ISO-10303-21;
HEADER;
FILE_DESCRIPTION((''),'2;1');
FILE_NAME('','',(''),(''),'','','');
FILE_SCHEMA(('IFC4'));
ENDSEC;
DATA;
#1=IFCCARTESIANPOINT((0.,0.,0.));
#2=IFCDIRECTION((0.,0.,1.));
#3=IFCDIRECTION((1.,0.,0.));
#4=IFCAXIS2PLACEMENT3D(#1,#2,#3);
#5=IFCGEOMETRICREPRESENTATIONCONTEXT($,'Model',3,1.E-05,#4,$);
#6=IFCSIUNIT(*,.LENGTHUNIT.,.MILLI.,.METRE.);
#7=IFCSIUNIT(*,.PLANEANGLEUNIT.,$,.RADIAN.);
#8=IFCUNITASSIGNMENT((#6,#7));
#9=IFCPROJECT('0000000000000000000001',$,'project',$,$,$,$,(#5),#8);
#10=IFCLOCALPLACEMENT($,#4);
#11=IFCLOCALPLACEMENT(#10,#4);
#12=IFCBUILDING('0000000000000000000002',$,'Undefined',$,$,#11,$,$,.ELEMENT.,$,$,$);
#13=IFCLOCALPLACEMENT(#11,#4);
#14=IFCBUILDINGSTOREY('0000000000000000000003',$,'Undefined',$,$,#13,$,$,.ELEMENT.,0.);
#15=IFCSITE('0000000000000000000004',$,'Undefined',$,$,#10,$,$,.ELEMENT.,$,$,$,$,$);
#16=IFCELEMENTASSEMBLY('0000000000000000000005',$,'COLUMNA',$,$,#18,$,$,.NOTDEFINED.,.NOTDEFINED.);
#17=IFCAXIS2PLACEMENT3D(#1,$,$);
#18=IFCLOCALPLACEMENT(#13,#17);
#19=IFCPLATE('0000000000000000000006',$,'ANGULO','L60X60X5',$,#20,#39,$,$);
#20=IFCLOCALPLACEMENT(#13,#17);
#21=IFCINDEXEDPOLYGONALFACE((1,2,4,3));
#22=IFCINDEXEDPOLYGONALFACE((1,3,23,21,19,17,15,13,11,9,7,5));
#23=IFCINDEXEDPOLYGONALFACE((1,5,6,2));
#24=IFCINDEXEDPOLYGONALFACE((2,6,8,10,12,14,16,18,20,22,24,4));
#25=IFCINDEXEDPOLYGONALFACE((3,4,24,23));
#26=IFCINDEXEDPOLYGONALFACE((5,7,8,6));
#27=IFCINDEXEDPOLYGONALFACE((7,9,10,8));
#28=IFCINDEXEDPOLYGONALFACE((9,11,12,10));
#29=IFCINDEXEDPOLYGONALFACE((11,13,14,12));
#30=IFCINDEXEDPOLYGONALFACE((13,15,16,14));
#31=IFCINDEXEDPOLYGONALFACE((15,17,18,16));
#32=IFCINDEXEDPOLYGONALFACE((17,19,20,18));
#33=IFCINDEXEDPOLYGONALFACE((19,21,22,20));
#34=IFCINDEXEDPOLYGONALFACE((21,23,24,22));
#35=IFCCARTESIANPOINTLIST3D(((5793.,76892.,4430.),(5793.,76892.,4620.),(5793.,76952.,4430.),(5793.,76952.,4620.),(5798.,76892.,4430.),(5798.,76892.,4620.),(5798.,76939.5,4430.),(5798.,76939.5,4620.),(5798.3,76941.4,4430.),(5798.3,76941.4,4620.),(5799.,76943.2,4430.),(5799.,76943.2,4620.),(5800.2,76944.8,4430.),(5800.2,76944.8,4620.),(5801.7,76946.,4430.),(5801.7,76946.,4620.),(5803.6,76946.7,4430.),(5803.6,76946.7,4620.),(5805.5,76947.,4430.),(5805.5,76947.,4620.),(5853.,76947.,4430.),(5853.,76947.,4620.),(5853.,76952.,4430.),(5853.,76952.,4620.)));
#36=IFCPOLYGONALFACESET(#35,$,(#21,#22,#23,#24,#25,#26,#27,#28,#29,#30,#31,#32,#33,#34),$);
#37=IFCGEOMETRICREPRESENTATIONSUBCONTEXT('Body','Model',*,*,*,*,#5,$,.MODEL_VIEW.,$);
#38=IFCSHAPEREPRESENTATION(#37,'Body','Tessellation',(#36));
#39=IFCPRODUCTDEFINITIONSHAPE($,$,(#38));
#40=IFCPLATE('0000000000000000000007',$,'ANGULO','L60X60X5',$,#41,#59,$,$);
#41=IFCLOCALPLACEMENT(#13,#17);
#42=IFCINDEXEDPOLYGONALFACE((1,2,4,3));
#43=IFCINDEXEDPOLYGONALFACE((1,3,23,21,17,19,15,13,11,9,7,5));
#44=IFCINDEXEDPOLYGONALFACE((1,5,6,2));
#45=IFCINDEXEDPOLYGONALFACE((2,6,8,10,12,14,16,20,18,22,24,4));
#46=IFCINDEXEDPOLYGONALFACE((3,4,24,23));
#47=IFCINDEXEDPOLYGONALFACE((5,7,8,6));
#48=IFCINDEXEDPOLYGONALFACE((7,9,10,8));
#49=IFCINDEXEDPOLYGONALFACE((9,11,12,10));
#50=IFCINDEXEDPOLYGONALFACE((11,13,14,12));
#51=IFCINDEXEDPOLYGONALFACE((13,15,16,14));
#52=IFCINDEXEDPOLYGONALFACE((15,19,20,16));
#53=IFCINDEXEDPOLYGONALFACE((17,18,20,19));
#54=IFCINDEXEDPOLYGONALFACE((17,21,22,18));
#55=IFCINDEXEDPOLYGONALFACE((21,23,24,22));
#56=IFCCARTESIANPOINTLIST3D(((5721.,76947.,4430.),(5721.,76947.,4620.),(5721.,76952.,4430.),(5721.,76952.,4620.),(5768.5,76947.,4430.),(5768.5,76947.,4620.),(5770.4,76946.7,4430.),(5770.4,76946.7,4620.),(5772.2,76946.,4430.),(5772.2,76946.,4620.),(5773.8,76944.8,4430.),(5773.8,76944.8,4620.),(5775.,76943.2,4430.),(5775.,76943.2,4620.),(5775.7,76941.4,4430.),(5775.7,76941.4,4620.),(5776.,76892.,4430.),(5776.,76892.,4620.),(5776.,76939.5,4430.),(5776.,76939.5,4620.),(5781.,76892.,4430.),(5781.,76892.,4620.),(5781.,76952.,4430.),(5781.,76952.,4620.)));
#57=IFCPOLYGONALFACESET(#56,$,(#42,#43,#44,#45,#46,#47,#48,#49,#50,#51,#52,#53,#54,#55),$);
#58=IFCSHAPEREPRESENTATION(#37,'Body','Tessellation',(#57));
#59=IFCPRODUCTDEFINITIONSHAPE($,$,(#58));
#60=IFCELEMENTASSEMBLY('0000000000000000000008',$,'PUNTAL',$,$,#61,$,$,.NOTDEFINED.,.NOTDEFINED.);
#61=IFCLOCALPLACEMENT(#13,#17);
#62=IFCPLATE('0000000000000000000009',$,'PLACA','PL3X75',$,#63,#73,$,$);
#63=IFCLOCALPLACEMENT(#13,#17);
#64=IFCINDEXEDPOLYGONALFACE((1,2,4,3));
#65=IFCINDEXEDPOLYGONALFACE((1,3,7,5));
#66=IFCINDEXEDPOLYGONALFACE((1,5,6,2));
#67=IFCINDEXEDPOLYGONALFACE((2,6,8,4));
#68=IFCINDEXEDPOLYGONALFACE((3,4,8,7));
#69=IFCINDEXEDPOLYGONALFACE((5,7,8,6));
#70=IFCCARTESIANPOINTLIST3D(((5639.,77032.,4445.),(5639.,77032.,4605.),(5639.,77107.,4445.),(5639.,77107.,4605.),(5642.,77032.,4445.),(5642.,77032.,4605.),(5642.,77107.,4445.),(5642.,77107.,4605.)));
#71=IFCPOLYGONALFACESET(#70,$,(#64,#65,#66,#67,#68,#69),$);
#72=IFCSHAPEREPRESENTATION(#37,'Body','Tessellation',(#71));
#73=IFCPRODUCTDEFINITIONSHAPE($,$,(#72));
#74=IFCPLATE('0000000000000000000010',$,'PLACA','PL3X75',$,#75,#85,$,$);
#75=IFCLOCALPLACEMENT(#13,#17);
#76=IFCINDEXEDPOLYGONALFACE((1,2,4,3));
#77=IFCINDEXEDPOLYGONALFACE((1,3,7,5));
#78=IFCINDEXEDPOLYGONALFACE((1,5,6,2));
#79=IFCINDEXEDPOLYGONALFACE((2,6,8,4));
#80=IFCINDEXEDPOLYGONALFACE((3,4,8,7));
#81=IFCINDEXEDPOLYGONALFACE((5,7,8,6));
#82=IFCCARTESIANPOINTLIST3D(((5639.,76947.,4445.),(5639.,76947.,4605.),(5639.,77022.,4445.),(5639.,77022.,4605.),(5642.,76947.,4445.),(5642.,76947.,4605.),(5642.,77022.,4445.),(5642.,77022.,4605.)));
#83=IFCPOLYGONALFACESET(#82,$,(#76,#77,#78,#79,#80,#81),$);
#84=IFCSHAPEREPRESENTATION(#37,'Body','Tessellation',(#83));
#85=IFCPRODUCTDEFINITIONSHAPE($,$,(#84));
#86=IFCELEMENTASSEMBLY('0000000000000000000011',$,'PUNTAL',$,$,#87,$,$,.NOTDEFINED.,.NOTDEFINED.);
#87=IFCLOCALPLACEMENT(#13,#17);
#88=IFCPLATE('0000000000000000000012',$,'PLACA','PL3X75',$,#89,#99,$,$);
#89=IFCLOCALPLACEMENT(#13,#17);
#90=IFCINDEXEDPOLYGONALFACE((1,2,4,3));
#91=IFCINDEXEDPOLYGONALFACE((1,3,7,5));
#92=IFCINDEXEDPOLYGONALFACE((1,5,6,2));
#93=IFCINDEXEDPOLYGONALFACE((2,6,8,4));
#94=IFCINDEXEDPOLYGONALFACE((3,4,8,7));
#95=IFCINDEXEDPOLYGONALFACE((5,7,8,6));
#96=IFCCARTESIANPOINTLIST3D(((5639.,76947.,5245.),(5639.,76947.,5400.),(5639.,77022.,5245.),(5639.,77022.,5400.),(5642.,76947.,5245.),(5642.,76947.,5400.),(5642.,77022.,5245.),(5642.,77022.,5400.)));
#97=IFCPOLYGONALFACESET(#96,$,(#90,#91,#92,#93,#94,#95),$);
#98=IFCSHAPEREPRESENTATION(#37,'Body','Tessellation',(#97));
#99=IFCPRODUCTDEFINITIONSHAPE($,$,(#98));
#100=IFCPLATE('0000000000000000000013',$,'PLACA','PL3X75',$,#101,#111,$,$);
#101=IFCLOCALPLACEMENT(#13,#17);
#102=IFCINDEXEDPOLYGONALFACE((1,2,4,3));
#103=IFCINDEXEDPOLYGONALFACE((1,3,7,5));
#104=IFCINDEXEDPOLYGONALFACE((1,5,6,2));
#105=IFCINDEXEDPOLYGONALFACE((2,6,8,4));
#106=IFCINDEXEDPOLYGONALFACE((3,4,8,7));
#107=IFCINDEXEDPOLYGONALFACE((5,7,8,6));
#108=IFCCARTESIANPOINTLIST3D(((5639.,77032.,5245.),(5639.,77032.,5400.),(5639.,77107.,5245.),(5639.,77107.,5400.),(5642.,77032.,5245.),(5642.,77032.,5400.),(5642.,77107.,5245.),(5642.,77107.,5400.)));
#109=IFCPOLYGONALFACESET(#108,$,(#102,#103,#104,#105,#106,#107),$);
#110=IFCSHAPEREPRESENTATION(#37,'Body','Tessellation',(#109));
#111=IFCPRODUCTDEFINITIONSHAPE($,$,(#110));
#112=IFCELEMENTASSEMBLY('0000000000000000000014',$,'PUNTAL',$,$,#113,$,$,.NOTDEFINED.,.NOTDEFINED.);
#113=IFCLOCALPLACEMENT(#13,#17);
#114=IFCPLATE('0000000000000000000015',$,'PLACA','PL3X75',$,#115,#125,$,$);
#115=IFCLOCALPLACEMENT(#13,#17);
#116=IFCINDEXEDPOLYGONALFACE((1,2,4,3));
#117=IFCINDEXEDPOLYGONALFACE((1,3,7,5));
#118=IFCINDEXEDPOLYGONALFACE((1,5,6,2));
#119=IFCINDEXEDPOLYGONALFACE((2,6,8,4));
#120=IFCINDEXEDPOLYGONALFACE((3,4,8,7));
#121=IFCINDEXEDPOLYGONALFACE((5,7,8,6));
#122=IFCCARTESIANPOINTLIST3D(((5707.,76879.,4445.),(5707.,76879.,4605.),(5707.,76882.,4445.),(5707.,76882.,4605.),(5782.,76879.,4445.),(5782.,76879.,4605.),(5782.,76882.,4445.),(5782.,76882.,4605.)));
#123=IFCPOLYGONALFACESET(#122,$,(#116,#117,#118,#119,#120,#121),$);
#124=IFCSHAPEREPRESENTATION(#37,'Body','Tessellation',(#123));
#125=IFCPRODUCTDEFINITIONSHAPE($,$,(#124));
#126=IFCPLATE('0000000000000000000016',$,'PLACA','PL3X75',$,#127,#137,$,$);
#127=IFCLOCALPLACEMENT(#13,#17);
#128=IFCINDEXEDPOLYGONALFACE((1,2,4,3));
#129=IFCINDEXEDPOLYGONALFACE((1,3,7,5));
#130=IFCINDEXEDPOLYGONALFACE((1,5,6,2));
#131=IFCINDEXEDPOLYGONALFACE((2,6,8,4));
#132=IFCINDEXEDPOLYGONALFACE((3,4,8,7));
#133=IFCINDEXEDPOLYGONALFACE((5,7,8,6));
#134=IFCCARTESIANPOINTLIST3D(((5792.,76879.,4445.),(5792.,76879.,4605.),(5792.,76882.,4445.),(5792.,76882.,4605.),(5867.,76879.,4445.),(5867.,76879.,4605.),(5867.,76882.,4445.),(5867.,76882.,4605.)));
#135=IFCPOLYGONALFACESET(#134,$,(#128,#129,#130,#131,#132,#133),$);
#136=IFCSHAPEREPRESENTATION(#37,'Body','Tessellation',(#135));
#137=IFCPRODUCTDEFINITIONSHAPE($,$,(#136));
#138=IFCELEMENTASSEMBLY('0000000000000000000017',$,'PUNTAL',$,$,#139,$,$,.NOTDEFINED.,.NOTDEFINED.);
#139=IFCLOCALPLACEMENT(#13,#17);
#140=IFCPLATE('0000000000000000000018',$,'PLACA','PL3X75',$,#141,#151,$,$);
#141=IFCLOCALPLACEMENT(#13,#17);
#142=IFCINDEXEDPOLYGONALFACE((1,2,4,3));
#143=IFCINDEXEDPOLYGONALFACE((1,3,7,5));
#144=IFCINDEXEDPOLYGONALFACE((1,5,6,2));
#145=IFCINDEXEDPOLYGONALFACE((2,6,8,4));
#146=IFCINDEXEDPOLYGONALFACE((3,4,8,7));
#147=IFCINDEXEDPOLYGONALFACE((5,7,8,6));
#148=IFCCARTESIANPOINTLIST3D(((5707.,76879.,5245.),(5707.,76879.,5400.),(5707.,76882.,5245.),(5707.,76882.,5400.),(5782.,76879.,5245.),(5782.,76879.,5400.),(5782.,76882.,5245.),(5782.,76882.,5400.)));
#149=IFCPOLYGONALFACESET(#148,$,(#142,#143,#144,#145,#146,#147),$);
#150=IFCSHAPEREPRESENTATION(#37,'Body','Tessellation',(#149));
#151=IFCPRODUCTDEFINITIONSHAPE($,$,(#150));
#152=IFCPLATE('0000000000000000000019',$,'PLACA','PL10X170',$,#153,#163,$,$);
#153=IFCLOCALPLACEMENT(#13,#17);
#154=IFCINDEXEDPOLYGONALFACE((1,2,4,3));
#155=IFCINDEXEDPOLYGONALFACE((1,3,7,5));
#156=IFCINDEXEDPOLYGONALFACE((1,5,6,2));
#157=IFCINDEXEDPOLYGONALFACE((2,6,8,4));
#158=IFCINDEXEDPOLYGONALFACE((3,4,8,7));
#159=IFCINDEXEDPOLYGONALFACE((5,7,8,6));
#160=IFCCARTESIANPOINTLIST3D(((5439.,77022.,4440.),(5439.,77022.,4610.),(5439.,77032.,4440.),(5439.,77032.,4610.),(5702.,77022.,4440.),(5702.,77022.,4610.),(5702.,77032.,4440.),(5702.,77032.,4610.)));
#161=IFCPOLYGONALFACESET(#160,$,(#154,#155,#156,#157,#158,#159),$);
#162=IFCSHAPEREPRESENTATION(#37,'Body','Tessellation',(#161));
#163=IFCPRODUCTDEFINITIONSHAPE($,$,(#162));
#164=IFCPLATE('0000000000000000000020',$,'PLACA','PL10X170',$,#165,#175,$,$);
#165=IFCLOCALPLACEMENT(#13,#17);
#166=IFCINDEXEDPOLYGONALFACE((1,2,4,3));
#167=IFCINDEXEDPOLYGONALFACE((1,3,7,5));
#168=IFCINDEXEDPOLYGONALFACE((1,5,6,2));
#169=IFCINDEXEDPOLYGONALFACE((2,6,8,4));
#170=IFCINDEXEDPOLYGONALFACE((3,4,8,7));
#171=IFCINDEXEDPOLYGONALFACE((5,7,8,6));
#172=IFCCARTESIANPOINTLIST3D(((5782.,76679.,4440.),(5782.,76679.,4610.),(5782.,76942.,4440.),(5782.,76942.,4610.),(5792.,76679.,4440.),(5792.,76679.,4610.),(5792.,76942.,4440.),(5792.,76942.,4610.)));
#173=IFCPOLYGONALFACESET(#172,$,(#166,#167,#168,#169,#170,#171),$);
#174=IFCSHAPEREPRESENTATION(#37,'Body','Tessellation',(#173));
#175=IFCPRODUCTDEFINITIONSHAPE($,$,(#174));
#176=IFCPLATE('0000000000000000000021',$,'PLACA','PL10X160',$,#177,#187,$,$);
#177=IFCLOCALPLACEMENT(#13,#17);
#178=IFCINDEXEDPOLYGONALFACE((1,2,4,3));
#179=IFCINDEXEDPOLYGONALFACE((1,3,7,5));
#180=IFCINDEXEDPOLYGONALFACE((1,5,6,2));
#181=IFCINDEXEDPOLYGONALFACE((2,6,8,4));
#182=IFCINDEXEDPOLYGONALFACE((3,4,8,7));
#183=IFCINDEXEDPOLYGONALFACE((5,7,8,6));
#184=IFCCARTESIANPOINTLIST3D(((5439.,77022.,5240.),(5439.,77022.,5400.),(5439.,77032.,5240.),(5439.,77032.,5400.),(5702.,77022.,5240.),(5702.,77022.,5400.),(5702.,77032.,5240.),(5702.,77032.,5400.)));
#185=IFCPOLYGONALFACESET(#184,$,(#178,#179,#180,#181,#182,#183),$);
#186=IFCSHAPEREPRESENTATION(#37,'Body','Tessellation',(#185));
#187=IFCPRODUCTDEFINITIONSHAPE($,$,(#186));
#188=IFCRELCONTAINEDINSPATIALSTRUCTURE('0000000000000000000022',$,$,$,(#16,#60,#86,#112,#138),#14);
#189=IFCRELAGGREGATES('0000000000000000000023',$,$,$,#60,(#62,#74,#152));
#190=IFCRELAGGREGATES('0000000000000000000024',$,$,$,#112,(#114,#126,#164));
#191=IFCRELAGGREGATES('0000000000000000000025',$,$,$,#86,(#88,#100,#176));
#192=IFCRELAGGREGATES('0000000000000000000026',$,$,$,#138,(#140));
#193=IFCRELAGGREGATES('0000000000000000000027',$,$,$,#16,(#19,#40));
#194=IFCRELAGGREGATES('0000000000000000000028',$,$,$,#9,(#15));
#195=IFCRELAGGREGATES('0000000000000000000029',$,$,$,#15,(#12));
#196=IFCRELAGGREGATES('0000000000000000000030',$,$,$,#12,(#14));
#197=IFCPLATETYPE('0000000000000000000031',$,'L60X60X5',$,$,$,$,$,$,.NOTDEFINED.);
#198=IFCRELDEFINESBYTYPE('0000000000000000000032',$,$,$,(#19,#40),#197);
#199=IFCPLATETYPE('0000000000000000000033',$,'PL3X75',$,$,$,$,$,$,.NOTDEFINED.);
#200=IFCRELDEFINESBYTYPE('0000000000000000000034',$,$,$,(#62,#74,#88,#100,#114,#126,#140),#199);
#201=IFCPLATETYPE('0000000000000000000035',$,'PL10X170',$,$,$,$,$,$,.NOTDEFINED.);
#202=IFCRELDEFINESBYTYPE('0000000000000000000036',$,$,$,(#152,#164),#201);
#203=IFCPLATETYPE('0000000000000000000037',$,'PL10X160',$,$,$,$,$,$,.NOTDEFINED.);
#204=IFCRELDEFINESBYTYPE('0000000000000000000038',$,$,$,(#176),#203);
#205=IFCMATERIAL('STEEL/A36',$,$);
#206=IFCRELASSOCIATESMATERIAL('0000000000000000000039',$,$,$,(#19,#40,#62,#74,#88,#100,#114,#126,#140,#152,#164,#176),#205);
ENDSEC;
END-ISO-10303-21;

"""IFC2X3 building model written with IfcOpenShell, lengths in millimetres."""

from ifc_helpers import new_model, si_unit, frame, origin_with_axes, origin_2d_with_axis, place, context, subcontext, project, spatial, polyline, l_section, outline, extrude, material, type_object, element, aggregate, save


model = new_model("IFC2X3")

# Units and contexts
model_context = context("Model", 3, precision=1e-05, world=origin_with_axes())
body_context = subcontext(model_context, "Body", "Model", "MODEL_VIEW")
ifc_project = project(units=[si_unit("LENGTHUNIT", "METRE", prefix="MILLI"), si_unit("PLANEANGLEUNIT", "RADIAN")], contexts=[model_context])

# Site, building, storey
site_placement = place(None, origin_with_axes())
site = spatial("IfcSite", under=ifc_project, at=site_placement, Name="Undefined", CompositionType="ELEMENT")
building_placement = place(site_placement, origin_with_axes())
building = spatial("IfcBuilding", under=site, at=building_placement, Name="Undefined", CompositionType="ELEMENT")
storey_placement = place(building_placement, origin_with_axes())
storey = spatial("IfcBuildingStorey", under=building, at=storey_placement, Name="Undefined", CompositionType="ELEMENT", Elevation=0.0)

# Element assembly, plates
assembly_1_placement = place(storey_placement, origin_with_axes())
assembly_1 = element("IfcElementAssembly", 1, at=assembly_1_placement, inside=storey, Name="COLUMNA", AssemblyPlace="NOTDEFINED", PredefinedType="NOTDEFINED")
ifc_material_1 = material(Name="STEEL/A36")
plate_type_1 = type_object("IfcPlateType", Name="L60X60X5", PredefinedType="NOTDEFINED")
plate_1_placement = place(assembly_1_placement, frame((5823.0, 76922.0, 4620.0), z_axis=(1.0, 0.0, 0.0), x_axis=(0.0, 0.0, -1.0)))
plate_1 = element("IfcPlate", 2, at=plate_1_placement, type_object=plate_type_1, material=ifc_material_1, Name="ANGULO", Description="L60X60X5", context=body_context, shape_type="SweptSolid", body=[
    extrude(l_section(Depth=60.0, Width=60.0, Thickness=5.0, FilletRadius=7.5, at=origin_2d_with_axis()), frame((190.0, 0.0, 0.0), z_axis=(-1.0, 0.0, 0.0), x_axis=(0.0, -1.0, 0.0)), (0.0, 0.0, 1.0), 190.0),
])
plate_2_placement = place(assembly_1_placement, frame((5751.0, 76922.0, 4430.0), z_axis=(-1.0, 0.0, 0.0), x_axis=(0.0, 0.0, 1.0)))
plate_2 = element("IfcPlate", 3, at=plate_2_placement, type_object=plate_type_1, material=ifc_material_1, Name="ANGULO", Description="L60X60X5", context=body_context, shape_type="SweptSolid", body=[
    extrude(l_section(Depth=60.0, Width=60.0, Thickness=5.0, FilletRadius=7.5, at=origin_2d_with_axis()), frame((190.0, 0.0, 0.0), z_axis=(-1.0, 0.0, 0.0), x_axis=(0.0, -1.0, 0.0)), (0.0, 0.0, 1.0), 190.0),
])

# Element assemblies, plates
assembly_2_placement = place(storey_placement, origin_with_axes())
assembly_2 = element("IfcElementAssembly", 4, at=assembly_2_placement, inside=storey, Name="PUNTAL", AssemblyPlace="NOTDEFINED", PredefinedType="NOTDEFINED")
plate_type_2 = type_object("IfcPlateType", Name="PL3X75", PredefinedType="NOTDEFINED")
plate_3_placement = place(assembly_2_placement, frame((5640.5, 77107.0, 4605.0), z_axis=(1.0, 0.0, 0.0), x_axis=(0.0, -1.0, 0.0)))
plate_3 = element("IfcPlate", 5, at=plate_3_placement, type_object=plate_type_2, material=ifc_material_1, Name="PLACA", Description="PL3X75", context=body_context, shape_type="SweptSolid", body=[
    extrude(outline(polyline([(0.0, 0.0), (75.0, 0.0), (75.0, 160.0), (0.0, 160.0), (0.0, 0.0)])), frame((0.0, 0.0, -1.5), z_axis=(0.0, 0.0, 1.0), x_axis=(1.0, 0.0, 0.0)), (0.0, 0.0, 1.0), 3.0),
])
plate_4_placement = place(assembly_2_placement, frame((5640.5, 77022.0, 4605.0), z_axis=(1.0, 0.0, 0.0), x_axis=(0.0, -1.0, 0.0)))
plate_4 = element("IfcPlate", 6, at=plate_4_placement, type_object=plate_type_2, material=ifc_material_1, Name="PLACA", Description="PL3X75", context=body_context, shape_type="SweptSolid", body=[
    extrude(outline(polyline([(0.0, 0.0), (75.0, 0.0), (75.0, 160.0), (0.0, 160.0), (0.0, 0.0)])), frame((0.0, 0.0, -1.5), z_axis=(0.0, 0.0, 1.0), x_axis=(1.0, 0.0, 0.0)), (0.0, 0.0, 1.0), 3.0),
])
assembly_3_placement = place(storey_placement, origin_with_axes())
assembly_3 = element("IfcElementAssembly", 7, at=assembly_3_placement, inside=storey, Name="PUNTAL", AssemblyPlace="NOTDEFINED", PredefinedType="NOTDEFINED")
plate_5_placement = place(assembly_3_placement, frame((5640.5, 76947.0, 5245.0), z_axis=(1.0, 0.0, 0.0), x_axis=(0.0, 1.0, 0.0)))
plate_5 = element("IfcPlate", 8, at=plate_5_placement, type_object=plate_type_2, material=ifc_material_1, Name="PLACA", Description="PL3X75", context=body_context, shape_type="SweptSolid", body=[
    extrude(outline(polyline([(0.0, 0.0), (75.0, 0.0), (75.0, 155.0), (0.0, 155.0), (0.0, 0.0)])), frame((0.0, 0.0, -1.5), z_axis=(0.0, 0.0, 1.0), x_axis=(1.0, 0.0, 0.0)), (0.0, 0.0, 1.0), 3.0),
])
plate_6_placement = place(assembly_3_placement, frame((5640.5, 77032.0, 5245.0), z_axis=(1.0, 0.0, 0.0), x_axis=(0.0, 1.0, 0.0)))
plate_6 = element("IfcPlate", 9, at=plate_6_placement, type_object=plate_type_2, material=ifc_material_1, Name="PLACA", Description="PL3X75", context=body_context, shape_type="SweptSolid", body=[
    extrude(outline(polyline([(0.0, 0.0), (75.0, 0.0), (75.0, 155.0), (0.0, 155.0), (0.0, 0.0)])), frame((0.0, 0.0, -1.5), z_axis=(0.0, 0.0, 1.0), x_axis=(1.0, 0.0, 0.0)), (0.0, 0.0, 1.0), 3.0),
])
assembly_4_placement = place(storey_placement, origin_with_axes())
assembly_4 = element("IfcElementAssembly", 10, at=assembly_4_placement, inside=storey, Name="PUNTAL", AssemblyPlace="NOTDEFINED", PredefinedType="NOTDEFINED")
plate_7_placement = place(assembly_4_placement, frame((5707.0, 76880.5, 4605.0), z_axis=(0.0, 1.0, 0.0), x_axis=(1.0, 0.0, 0.0)))
plate_7 = element("IfcPlate", 11, at=plate_7_placement, type_object=plate_type_2, material=ifc_material_1, Name="PLACA", Description="PL3X75", context=body_context, shape_type="SweptSolid", body=[
    extrude(outline(polyline([(0.0, 0.0), (75.0, 0.0), (75.0, 160.0), (0.0, 160.0), (0.0, 0.0)])), frame((0.0, 0.0, -1.5), z_axis=(0.0, 0.0, 1.0), x_axis=(1.0, 0.0, 0.0)), (0.0, 0.0, 1.0), 3.0),
])
plate_8_placement = place(assembly_4_placement, frame((5792.0, 76880.5, 4605.0), z_axis=(0.0, 1.0, 0.0), x_axis=(1.0, 0.0, 0.0)))
plate_8 = element("IfcPlate", 12, at=plate_8_placement, type_object=plate_type_2, material=ifc_material_1, Name="PLACA", Description="PL3X75", context=body_context, shape_type="SweptSolid", body=[
    extrude(outline(polyline([(0.0, 0.0), (75.0, 0.0), (75.0, 160.0), (0.0, 160.0), (0.0, 0.0)])), frame((0.0, 0.0, -1.5), z_axis=(0.0, 0.0, 1.0), x_axis=(1.0, 0.0, 0.0)), (0.0, 0.0, 1.0), 3.0),
])

# Element assembly, plate
assembly_5_placement = place(storey_placement, origin_with_axes())
assembly_5 = element("IfcElementAssembly", 13, at=assembly_5_placement, inside=storey, Name="PUNTAL", AssemblyPlace="NOTDEFINED", PredefinedType="NOTDEFINED")
plate_9_placement = place(assembly_5_placement, frame((5782.0, 76880.5, 5245.0), z_axis=(0.0, 1.0, 0.0), x_axis=(-1.0, 0.0, 0.0)))
plate_9 = element("IfcPlate", 14, at=plate_9_placement, type_object=plate_type_2, material=ifc_material_1, Name="PLACA", Description="PL3X75", context=body_context, shape_type="SweptSolid", body=[
    extrude(outline(polyline([(0.0, 0.0), (75.0, 0.0), (75.0, 155.0), (0.0, 155.0), (0.0, 0.0)])), frame((0.0, 0.0, -1.5), z_axis=(0.0, 0.0, 1.0), x_axis=(1.0, 0.0, 0.0)), (0.0, 0.0, 1.0), 3.0),
])

# Plates
plate_type_3 = type_object("IfcPlateType", Name="PL10X170", PredefinedType="NOTDEFINED")
plate_10_placement = place(assembly_2_placement, frame((5702.0, 77027.0, 4525.0), z_axis=(0.0, 1.0, 0.0), x_axis=(-1.0, 0.0, 0.0)))
plate_10 = element("IfcPlate", 15, at=plate_10_placement, type_object=plate_type_3, material=ifc_material_1, Name="PLACA", Description="PL10X170", context=body_context, shape_type="SweptSolid", body=[
    extrude(outline(polyline([(0.0, -85.0), (0.0, 85.0), (263.0, 85.0), (263.0, -85.0), (0.0, -85.0)])), frame((0.0, 0.0, -5.0), z_axis=(0.0, 0.0, 1.0), x_axis=(1.0, 0.0, 0.0)), (0.0, 0.0, 1.0), 10.0),
])
aggregate(assembly_2, [plate_3, plate_4, plate_10])
plate_11_placement = place(assembly_4_placement, frame((5787.0, 76942.0, 4525.0), z_axis=(-1.0, 0.0, 0.0), x_axis=(0.0, -1.0, 0.0)))
plate_11 = element("IfcPlate", 16, at=plate_11_placement, type_object=plate_type_3, material=ifc_material_1, Name="PLACA", Description="PL10X170", context=body_context, shape_type="SweptSolid", body=[
    extrude(outline(polyline([(0.0, -85.0), (0.0, 85.0), (263.0, 85.0), (263.0, -85.0), (0.0, -85.0)])), frame((0.0, 0.0, -5.0), z_axis=(0.0, 0.0, 1.0), x_axis=(1.0, 0.0, 0.0)), (0.0, 0.0, 1.0), 10.0),
])
aggregate(assembly_4, [plate_7, plate_8, plate_11])
plate_type_4 = type_object("IfcPlateType", Name="PL10X160", PredefinedType="NOTDEFINED")
plate_12_placement = place(assembly_3_placement, frame((5702.0, 77027.0, 5320.0), z_axis=(0.0, -1.0, 0.0), x_axis=(-1.0, 0.0, 0.0)))
plate_12 = element("IfcPlate", 17, at=plate_12_placement, type_object=plate_type_4, material=ifc_material_1, Name="PLACA", Description="PL10X160", context=body_context, shape_type="SweptSolid", body=[
    extrude(outline(polyline([(0.0, -80.0), (0.0, 80.0), (263.0, 80.0), (263.0, -80.0), (0.0, -80.0)])), frame((0.0, 0.0, -5.0), z_axis=(0.0, 0.0, 1.0), x_axis=(1.0, 0.0, 0.0)), (0.0, 0.0, 1.0), 10.0),
])
aggregate(assembly_3, [plate_5, plate_6, plate_12])
aggregate(assembly_5, [plate_9])

aggregate(assembly_1, [plate_1, plate_2])

save(model, "model.ifc")
